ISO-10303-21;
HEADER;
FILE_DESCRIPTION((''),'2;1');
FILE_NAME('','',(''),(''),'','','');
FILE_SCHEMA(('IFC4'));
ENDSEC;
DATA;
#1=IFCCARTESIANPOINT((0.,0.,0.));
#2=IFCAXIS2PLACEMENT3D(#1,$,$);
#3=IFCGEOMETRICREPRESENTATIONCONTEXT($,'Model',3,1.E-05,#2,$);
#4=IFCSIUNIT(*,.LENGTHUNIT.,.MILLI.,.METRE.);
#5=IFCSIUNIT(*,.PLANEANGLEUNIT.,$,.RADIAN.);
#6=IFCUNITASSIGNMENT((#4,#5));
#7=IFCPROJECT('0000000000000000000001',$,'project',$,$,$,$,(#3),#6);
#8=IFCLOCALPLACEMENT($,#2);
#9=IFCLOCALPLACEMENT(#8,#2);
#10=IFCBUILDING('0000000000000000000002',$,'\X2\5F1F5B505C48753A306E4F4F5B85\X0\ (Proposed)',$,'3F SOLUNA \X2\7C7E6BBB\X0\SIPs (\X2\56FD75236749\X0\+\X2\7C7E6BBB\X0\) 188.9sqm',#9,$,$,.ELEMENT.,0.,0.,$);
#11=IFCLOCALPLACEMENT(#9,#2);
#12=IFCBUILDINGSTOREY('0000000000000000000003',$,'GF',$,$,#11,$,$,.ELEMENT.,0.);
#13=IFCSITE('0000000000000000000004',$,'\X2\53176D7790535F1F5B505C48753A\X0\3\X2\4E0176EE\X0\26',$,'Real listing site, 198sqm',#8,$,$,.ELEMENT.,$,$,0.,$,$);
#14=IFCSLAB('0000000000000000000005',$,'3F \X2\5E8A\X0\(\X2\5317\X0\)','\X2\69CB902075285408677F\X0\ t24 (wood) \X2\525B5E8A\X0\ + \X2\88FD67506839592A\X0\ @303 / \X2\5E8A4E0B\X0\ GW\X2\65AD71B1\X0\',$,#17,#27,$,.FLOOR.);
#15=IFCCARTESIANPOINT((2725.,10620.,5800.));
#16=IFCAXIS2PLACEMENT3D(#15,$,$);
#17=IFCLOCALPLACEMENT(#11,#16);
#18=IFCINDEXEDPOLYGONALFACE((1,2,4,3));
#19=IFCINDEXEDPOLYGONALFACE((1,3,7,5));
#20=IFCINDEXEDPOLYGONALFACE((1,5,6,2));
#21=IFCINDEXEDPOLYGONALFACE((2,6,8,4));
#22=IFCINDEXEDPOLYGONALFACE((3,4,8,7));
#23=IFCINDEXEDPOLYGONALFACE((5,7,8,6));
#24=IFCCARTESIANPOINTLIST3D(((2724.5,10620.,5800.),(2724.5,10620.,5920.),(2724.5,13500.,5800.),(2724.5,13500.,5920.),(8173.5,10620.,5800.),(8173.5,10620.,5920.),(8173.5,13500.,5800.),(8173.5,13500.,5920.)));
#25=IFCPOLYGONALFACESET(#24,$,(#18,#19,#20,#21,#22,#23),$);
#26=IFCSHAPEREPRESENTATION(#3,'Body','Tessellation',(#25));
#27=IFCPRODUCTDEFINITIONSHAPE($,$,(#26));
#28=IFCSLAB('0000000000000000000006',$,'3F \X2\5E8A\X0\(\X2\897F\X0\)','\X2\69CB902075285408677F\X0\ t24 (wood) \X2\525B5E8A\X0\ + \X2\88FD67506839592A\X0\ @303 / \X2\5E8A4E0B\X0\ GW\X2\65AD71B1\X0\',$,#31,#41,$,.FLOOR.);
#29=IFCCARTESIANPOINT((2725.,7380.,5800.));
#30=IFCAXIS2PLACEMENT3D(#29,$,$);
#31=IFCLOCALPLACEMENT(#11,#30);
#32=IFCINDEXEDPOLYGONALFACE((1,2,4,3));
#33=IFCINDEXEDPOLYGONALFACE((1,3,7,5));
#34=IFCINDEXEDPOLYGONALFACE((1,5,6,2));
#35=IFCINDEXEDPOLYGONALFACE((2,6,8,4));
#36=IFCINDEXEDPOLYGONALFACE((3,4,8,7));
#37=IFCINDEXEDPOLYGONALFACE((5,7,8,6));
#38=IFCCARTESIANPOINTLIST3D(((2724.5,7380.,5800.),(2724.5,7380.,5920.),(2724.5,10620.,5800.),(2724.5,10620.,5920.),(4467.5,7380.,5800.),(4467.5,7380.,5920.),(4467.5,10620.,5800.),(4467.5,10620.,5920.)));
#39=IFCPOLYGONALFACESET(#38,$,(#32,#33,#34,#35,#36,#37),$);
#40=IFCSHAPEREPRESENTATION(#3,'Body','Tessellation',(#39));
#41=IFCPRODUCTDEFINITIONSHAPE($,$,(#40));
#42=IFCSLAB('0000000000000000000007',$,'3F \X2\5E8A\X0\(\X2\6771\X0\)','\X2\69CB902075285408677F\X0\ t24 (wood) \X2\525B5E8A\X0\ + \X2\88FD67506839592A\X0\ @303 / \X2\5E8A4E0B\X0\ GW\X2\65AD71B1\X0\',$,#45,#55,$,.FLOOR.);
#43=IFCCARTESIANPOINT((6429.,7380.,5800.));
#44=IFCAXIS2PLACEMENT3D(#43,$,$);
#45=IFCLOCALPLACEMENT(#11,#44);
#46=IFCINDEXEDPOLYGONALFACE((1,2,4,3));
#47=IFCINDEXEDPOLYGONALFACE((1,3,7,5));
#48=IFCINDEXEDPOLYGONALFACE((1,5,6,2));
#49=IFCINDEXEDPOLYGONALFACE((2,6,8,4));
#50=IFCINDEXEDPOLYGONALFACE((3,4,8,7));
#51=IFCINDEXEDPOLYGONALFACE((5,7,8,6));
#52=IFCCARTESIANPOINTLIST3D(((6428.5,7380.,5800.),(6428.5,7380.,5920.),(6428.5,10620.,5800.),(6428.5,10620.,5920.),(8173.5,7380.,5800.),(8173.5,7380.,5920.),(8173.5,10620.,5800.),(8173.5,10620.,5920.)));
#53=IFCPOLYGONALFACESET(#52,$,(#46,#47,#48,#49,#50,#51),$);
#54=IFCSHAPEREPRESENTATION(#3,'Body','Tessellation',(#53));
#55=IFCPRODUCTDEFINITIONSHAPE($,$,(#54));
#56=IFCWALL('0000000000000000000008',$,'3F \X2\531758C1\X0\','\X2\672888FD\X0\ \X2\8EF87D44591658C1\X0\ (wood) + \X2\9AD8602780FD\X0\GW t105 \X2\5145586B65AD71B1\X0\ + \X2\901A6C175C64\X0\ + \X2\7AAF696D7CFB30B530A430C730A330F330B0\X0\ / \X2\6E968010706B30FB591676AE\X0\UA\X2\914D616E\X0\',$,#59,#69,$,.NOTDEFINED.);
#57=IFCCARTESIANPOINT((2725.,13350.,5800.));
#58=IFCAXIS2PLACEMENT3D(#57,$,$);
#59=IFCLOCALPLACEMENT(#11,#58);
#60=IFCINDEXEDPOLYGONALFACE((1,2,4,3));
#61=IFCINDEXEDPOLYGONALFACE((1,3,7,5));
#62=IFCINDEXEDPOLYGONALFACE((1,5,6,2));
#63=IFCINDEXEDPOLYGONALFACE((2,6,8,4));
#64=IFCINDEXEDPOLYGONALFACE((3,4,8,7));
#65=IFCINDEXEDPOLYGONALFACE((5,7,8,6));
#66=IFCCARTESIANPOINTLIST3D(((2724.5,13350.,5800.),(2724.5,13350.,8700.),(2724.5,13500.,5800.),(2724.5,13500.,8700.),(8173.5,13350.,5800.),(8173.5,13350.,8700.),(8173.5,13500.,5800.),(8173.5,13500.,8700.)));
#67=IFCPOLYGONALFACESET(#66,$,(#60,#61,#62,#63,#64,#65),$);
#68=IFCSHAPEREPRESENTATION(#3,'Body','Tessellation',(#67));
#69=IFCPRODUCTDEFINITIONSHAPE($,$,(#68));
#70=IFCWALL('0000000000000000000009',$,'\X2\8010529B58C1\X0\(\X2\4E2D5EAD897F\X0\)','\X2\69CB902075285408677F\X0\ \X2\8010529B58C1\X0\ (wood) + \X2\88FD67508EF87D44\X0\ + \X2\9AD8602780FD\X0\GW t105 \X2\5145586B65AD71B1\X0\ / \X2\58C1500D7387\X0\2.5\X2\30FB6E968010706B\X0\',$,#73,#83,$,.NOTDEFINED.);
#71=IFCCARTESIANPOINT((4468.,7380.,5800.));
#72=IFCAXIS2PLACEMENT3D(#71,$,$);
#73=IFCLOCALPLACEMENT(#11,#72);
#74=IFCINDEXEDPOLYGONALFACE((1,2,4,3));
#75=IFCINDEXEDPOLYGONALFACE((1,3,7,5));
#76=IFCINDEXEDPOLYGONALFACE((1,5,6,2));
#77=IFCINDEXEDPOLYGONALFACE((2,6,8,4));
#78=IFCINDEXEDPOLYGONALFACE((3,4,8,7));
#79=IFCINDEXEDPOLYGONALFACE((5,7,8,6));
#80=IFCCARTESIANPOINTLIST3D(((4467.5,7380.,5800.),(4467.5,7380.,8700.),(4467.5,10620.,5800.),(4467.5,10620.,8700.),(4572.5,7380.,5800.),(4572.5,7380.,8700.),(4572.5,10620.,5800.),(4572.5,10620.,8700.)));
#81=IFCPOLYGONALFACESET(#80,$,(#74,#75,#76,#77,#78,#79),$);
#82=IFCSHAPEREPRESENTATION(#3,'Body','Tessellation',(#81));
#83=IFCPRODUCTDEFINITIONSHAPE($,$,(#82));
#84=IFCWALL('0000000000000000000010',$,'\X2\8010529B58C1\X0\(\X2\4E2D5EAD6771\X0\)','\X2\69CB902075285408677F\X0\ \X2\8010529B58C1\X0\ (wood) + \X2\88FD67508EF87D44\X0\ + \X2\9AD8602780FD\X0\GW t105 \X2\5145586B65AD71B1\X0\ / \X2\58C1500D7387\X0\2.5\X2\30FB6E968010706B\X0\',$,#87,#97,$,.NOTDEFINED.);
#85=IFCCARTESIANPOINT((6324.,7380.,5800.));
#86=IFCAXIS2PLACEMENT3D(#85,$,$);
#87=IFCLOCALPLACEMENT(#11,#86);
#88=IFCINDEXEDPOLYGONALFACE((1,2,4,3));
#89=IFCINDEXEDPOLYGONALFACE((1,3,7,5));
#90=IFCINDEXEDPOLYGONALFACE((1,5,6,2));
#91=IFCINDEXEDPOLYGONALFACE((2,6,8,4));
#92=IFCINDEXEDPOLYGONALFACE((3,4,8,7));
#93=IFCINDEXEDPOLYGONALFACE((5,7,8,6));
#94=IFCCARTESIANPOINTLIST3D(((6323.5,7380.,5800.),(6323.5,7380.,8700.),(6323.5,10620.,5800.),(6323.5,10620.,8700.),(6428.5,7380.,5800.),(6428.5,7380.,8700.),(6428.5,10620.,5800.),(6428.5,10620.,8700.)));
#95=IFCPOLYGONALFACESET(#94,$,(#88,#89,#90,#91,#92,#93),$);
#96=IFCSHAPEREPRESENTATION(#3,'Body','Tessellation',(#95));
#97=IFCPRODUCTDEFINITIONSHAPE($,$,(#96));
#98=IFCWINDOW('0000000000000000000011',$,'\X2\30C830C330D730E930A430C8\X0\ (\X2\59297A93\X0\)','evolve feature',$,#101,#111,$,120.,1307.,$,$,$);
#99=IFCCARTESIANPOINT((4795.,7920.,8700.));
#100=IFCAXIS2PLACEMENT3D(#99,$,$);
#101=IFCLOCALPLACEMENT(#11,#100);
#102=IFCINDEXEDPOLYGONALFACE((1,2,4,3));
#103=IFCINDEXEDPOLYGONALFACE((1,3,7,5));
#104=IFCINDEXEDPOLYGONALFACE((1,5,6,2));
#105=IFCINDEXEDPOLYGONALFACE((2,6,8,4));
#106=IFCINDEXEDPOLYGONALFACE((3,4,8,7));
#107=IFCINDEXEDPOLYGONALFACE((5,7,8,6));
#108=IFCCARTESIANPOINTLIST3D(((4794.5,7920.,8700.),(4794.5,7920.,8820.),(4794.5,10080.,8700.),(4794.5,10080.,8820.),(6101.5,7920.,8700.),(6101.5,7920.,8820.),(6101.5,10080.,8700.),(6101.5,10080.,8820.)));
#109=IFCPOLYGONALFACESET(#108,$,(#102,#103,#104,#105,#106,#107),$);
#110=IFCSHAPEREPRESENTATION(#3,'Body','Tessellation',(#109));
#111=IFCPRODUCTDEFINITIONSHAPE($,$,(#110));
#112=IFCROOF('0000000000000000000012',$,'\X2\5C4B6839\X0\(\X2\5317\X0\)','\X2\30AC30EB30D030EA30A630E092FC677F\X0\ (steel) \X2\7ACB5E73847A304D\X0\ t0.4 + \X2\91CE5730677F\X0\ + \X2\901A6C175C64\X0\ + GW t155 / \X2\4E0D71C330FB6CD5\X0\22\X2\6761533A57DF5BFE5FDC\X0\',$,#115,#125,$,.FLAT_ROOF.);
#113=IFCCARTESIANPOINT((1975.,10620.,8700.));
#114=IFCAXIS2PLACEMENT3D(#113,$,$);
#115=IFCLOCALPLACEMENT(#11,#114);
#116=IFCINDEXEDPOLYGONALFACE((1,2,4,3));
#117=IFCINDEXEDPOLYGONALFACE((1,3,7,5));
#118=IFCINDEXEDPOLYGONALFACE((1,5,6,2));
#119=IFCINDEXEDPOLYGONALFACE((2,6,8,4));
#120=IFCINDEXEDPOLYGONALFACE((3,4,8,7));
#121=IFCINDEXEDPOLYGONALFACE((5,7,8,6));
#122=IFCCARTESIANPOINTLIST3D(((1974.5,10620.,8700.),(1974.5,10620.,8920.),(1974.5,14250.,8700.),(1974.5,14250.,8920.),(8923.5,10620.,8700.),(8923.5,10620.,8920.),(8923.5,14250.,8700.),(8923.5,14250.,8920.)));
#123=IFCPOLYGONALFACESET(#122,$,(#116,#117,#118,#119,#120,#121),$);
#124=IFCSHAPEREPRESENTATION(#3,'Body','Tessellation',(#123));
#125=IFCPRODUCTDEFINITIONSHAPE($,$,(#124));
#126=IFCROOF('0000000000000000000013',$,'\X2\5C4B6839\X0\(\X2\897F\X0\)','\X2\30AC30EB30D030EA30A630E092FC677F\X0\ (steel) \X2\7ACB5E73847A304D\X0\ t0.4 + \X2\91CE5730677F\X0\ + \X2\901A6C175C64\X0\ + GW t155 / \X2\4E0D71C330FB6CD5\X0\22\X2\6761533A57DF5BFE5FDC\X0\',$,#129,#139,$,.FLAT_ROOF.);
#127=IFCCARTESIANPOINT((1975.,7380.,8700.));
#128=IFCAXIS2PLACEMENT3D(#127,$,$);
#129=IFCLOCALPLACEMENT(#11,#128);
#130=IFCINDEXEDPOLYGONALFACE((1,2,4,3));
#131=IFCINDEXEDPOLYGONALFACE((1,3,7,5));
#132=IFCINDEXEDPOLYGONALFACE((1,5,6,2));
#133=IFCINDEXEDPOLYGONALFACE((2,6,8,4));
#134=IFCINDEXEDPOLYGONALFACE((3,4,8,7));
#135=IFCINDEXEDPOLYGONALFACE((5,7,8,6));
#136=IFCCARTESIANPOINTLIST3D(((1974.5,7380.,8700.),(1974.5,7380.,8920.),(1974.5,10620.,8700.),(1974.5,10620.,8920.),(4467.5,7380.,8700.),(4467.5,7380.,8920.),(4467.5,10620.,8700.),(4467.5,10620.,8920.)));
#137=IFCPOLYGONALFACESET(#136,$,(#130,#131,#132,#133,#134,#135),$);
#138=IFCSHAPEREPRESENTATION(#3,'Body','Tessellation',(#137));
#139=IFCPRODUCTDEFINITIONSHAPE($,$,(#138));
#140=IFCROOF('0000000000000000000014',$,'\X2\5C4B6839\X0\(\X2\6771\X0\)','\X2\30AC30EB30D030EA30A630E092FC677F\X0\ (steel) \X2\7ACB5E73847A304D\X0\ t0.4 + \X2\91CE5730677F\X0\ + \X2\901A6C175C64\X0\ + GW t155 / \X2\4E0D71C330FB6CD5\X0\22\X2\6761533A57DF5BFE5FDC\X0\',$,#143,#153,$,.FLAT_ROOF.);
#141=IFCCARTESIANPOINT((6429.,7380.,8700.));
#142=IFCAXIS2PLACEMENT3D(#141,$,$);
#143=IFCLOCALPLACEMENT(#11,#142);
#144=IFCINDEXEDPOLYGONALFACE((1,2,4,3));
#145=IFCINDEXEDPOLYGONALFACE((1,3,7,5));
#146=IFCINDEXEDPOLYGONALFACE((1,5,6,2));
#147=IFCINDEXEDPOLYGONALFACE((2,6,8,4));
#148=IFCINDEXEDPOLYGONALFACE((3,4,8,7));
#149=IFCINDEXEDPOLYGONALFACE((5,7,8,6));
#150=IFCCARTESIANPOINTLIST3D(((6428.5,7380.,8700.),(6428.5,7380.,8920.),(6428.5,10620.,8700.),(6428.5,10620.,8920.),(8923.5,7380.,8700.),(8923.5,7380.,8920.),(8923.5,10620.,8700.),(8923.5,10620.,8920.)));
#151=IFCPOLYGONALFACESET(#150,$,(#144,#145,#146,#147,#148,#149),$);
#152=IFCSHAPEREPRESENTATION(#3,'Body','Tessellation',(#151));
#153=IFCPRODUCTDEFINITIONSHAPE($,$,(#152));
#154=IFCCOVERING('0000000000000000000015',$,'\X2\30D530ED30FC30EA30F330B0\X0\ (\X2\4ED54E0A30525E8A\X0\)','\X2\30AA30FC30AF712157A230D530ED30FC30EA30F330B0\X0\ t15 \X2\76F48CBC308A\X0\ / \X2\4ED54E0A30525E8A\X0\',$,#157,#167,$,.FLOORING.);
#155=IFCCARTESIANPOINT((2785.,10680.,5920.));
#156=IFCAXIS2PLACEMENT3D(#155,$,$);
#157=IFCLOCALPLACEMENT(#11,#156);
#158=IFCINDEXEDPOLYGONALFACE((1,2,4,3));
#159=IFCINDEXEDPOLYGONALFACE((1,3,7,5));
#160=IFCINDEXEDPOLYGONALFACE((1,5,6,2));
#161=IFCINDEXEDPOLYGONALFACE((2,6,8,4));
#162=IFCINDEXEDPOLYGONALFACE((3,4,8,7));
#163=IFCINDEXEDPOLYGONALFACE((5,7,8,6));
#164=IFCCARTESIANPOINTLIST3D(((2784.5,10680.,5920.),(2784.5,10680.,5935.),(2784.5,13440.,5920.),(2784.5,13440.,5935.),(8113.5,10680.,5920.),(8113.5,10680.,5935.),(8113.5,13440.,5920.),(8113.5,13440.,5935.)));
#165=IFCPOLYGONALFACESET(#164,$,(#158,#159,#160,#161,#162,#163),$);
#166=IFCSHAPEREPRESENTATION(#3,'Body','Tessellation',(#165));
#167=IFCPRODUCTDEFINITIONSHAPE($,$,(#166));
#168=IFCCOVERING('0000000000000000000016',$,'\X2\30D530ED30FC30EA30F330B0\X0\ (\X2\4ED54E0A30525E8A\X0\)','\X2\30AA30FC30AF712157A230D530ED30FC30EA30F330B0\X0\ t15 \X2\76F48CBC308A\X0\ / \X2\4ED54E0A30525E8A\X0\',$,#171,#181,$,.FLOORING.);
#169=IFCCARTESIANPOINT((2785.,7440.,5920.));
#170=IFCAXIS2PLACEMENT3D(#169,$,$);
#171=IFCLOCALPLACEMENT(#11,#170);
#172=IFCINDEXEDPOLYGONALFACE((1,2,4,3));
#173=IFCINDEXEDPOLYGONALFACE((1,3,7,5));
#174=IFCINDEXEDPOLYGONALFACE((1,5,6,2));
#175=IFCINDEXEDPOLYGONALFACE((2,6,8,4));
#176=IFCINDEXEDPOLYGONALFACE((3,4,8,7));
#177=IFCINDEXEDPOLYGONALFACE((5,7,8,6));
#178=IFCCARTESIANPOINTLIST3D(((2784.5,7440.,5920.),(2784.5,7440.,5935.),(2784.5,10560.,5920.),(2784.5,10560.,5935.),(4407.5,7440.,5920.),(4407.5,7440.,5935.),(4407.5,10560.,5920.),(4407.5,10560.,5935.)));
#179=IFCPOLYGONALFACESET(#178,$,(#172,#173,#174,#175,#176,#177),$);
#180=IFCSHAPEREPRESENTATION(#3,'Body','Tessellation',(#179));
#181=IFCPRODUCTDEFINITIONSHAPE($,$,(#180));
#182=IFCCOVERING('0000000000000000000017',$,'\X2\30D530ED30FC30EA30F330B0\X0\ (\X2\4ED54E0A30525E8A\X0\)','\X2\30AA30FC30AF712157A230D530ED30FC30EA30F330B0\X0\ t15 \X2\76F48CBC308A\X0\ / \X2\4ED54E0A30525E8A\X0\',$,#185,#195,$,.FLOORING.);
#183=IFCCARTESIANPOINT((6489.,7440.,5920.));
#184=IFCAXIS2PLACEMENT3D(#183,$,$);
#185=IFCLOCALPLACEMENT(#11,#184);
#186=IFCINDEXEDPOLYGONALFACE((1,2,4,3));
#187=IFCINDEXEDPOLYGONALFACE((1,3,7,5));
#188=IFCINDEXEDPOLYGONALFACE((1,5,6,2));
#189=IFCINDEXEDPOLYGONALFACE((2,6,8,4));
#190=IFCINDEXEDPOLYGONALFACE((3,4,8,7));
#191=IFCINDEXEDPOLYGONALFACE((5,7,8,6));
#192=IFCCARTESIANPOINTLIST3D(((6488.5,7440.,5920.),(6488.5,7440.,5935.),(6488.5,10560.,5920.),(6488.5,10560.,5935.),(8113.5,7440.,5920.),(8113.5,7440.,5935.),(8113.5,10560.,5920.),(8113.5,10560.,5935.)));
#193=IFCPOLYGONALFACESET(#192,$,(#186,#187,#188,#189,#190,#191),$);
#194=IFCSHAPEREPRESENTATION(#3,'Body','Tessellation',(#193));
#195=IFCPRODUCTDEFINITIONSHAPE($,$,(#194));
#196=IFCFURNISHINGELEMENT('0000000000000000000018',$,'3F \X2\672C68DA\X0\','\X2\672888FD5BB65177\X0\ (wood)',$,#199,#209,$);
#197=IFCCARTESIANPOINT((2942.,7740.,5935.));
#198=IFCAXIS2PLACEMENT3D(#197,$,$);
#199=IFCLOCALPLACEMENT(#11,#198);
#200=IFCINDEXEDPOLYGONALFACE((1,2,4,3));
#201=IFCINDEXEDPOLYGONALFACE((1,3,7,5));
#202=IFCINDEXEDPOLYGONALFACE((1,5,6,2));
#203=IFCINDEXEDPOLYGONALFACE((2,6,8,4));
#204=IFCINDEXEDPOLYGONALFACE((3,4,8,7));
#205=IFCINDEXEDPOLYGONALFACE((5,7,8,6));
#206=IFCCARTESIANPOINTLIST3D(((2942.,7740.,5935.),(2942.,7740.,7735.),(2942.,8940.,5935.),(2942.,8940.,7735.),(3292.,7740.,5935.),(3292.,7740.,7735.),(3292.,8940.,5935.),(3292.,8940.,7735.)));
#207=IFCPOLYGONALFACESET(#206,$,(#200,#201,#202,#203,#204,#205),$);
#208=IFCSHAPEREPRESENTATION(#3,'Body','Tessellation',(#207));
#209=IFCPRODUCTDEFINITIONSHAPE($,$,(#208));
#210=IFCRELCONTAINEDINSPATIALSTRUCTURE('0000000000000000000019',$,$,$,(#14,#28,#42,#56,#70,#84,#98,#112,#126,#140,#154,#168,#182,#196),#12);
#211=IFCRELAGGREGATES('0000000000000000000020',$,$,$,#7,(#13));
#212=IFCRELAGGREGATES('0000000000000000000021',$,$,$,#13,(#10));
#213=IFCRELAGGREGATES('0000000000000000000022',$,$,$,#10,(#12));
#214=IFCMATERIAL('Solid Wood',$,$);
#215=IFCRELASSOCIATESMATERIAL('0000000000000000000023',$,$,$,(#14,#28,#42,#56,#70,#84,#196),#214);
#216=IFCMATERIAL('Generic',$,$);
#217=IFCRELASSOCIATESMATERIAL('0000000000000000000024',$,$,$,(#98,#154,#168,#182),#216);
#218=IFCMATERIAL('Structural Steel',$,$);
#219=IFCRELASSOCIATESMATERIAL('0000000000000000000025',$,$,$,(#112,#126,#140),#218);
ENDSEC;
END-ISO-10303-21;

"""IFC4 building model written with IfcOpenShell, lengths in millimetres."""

from ifc_helpers import new_model, si_unit, frame, frame_2d, origin, place, context, project, spatial, rectangle, extrude, material, element, save


model = new_model("IFC4")

# Units and contexts
model_context = context("Model", 3, precision=1e-05, world=origin())
ifc_project = project(units=[si_unit("LENGTHUNIT", "METRE", prefix="MILLI"), si_unit("PLANEANGLEUNIT", "RADIAN")], contexts=[model_context])

# Site, building, storey
site_placement = place(None, origin())
site = spatial("IfcSite", under=ifc_project, at=site_placement, Name="北海道弟子屈町3丁目26", ObjectType="Real listing site, 198sqm", CompositionType="ELEMENT", RefElevation=0.0)
building_placement = place(site_placement, origin())
building = spatial("IfcBuilding", under=site, at=building_placement, Name="弟子屈町の住宅 (Proposed)", ObjectType="3F SOLUNA 籾殻SIPs (国産杉+籾殻) 188.9sqm", CompositionType="ELEMENT", ElevationOfRefHeight=0.0, ElevationOfTerrain=0.0)
storey_placement = place(building_placement, origin())
storey = spatial("IfcBuildingStorey", under=building, at=storey_placement, Name="GF", CompositionType="ELEMENT", Elevation=0.0)

# Slabs
ifc_material_1 = material(Name="Solid Wood")
slab_1_placement = place(storey_placement, frame((2725.0, 10620.0, 5800.0)))
element("IfcSlab", 1, at=slab_1_placement, inside=storey, material=ifc_material_1, Name="3F 床(北)", Description="構造用合板 t24 (wood) 剛床 + 製材根太 @303 / 床下 GW断熱", PredefinedType="FLOOR", context=model_context, shape_type="SweptSolid", body=[
    extrude(rectangle(XDim=5449.0, YDim=2880.0, at=frame_2d((2724.0, 1440.0))), frame((2725.0, 10620.0, 5800.0)), (0.0, 0.0, 1.0), 120.0),
])
slab_2_placement = place(storey_placement, frame((2725.0, 7380.0, 5800.0)))
element("IfcSlab", 2, at=slab_2_placement, inside=storey, material=ifc_material_1, Name="3F 床(西)", Description="構造用合板 t24 (wood) 剛床 + 製材根太 @303 / 床下 GW断熱", PredefinedType="FLOOR", context=model_context, shape_type="SweptSolid", body=[
    extrude(rectangle(XDim=1743.0, YDim=3240.0, at=frame_2d((871.0, 1620.0))), frame((2725.0, 7380.0, 5800.0)), (0.0, 0.0, 1.0), 120.0),
])
slab_3_placement = place(storey_placement, frame((6429.0, 7380.0, 5800.0)))
element("IfcSlab", 3, at=slab_3_placement, inside=storey, material=ifc_material_1, Name="3F 床(東)", Description="構造用合板 t24 (wood) 剛床 + 製材根太 @303 / 床下 GW断熱", PredefinedType="FLOOR", context=model_context, shape_type="SweptSolid", body=[
    extrude(rectangle(XDim=1745.0, YDim=3240.0, at=frame_2d((872.0, 1620.0))), frame((6429.0, 7380.0, 5800.0)), (0.0, 0.0, 1.0), 120.0),
])

# Wall
wall_1_placement = place(storey_placement, frame((2725.0, 13350.0, 5800.0)))
element("IfcWall", 4, at=wall_1_placement, inside=storey, material=ifc_material_1, Name="3F 北壁", Description="木製 軸組外壁 (wood) + 高性能GW t105 充填断熱 + 通気層 + 窯業系サイディング / 準耐火・外皮UA配慮", PredefinedType="NOTDEFINED", context=model_context, shape_type="SweptSolid", body=[
    extrude(rectangle(XDim=5449.0, YDim=150.0, at=frame_2d((2724.0, 75.0))), frame((2725.0, 13350.0, 5800.0)), (0.0, 0.0, 1.0), 2900.0),
])

# Walls
wall_2_placement = place(storey_placement, frame((4468.0, 7380.0, 5800.0)))
element("IfcWall", 5, at=wall_2_placement, inside=storey, material=ifc_material_1, Name="耐力壁(中庭西)", Description="構造用合板 耐力壁 (wood) + 製材軸組 + 高性能GW t105 充填断熱 / 壁倍率2.5・準耐火", PredefinedType="NOTDEFINED", context=model_context, shape_type="SweptSolid", body=[
    extrude(rectangle(XDim=105.0, YDim=3240.0, at=frame_2d((52.0, 1620.0))), frame((4468.0, 7380.0, 5800.0)), (0.0, 0.0, 1.0), 2900.0),
])
wall_3_placement = place(storey_placement, frame((6324.0, 7380.0, 5800.0)))
element("IfcWall", 6, at=wall_3_placement, inside=storey, material=ifc_material_1, Name="耐力壁(中庭東)", Description="構造用合板 耐力壁 (wood) + 製材軸組 + 高性能GW t105 充填断熱 / 壁倍率2.5・準耐火", PredefinedType="NOTDEFINED", context=model_context, shape_type="SweptSolid", body=[
    extrude(rectangle(XDim=105.0, YDim=3240.0, at=frame_2d((52.0, 1620.0))), frame((6324.0, 7380.0, 5800.0)), (0.0, 0.0, 1.0), 2900.0),
])

# Window
ifc_material_2 = material(Name="Generic")
window_1_placement = place(storey_placement, frame((4795.0, 7920.0, 8700.0)))
element("IfcWindow", 7, at=window_1_placement, inside=storey, material=ifc_material_2, Name="トップライト (天窓)", Description="evolve feature", OverallHeight=120.0, OverallWidth=1307.0, context=model_context, shape_type="SweptSolid", body=[
    extrude(rectangle(XDim=1307.0, YDim=2160.0, at=frame_2d((653.0, 1080.0))), frame((4795.0, 7920.0, 8700.0)), (0.0, 0.0, 1.0), 120.0),
])

# Roofs
ifc_material_3 = material(Name="Structural Steel")
for number, where, name in (
    (8, (1975.0, 10620.0, 8700.0), "屋根(北)"),
):
    element("IfcRoof", number, at=place(storey_placement, frame(where)), inside=storey, material=ifc_material_3, Name=name, Description="ガルバリウム鋼板 (steel) 立平葺き t0.4 + 野地板 + 通気層 + GW t155 / 不燃・法22条区域対応", PredefinedType="FLAT_ROOF", context=model_context, shape_type="SweptSolid", body=[
        extrude(rectangle(XDim=6949.0, YDim=3630.0, at=frame_2d((3474.0, 1815.0))), frame((1975.0, 10620.0, 8700.0)), (0.0, 0.0, 1.0), 220.0),
    ])
roof_1_placement = place(storey_placement, frame((1975.0, 7380.0, 8700.0)))
element("IfcRoof", 9, at=roof_1_placement, inside=storey, material=ifc_material_3, Name="屋根(西)", Description="ガルバリウム鋼板 (steel) 立平葺き t0.4 + 野地板 + 通気層 + GW t155 / 不燃・法22条区域対応", PredefinedType="FLAT_ROOF", context=model_context, shape_type="SweptSolid", body=[
    extrude(rectangle(XDim=2493.0, YDim=3240.0, at=frame_2d((1246.0, 1620.0))), frame((1975.0, 7380.0, 8700.0)), (0.0, 0.0, 1.0), 220.0),
])
roof_2_placement = place(storey_placement, frame((6429.0, 7380.0, 8700.0)))
element("IfcRoof", 10, at=roof_2_placement, inside=storey, material=ifc_material_3, Name="屋根(東)", Description="ガルバリウム鋼板 (steel) 立平葺き t0.4 + 野地板 + 通気層 + GW t155 / 不燃・法22条区域対応", PredefinedType="FLAT_ROOF", context=model_context, shape_type="SweptSolid", body=[
    extrude(rectangle(XDim=2495.0, YDim=3240.0, at=frame_2d((1247.0, 1620.0))), frame((6429.0, 7380.0, 8700.0)), (0.0, 0.0, 1.0), 220.0),
])

# Coverings
covering_1_placement = place(storey_placement, frame((2785.0, 10680.0, 5920.0)))
element("IfcCovering", 11, at=covering_1_placement, inside=storey, material=ifc_material_2, Name="フローリング (仕上げ床)", Description="オーク無垢フローリング t15 直貼り / 仕上げ床", PredefinedType="FLOORING", context=model_context, shape_type="SweptSolid", body=[
    extrude(rectangle(XDim=5329.0, YDim=2760.0, at=frame_2d((2664.0, 1380.0))), frame((2785.0, 10680.0, 5920.0)), (0.0, 0.0, 1.0), 15.0),
])
covering_2_placement = place(storey_placement, frame((2785.0, 7440.0, 5920.0)))
element("IfcCovering", 12, at=covering_2_placement, inside=storey, material=ifc_material_2, Name="フローリング (仕上げ床)", Description="オーク無垢フローリング t15 直貼り / 仕上げ床", PredefinedType="FLOORING", context=model_context, shape_type="SweptSolid", body=[
    extrude(rectangle(XDim=1623.0, YDim=3120.0, at=frame_2d((811.0, 1560.0))), frame((2785.0, 7440.0, 5920.0)), (0.0, 0.0, 1.0), 15.0),
])
covering_3_placement = place(storey_placement, frame((6489.0, 7440.0, 5920.0)))
element("IfcCovering", 13, at=covering_3_placement, inside=storey, material=ifc_material_2, Name="フローリング (仕上げ床)", Description="オーク無垢フローリング t15 直貼り / 仕上げ床", PredefinedType="FLOORING", context=model_context, shape_type="SweptSolid", body=[
    extrude(rectangle(XDim=1625.0, YDim=3120.0, at=frame_2d((812.0, 1560.0))), frame((6489.0, 7440.0, 5920.0)), (0.0, 0.0, 1.0), 15.0),
])

# Furnishing element
furnishing_placement = place(storey_placement, frame((2942.0, 7740.0, 5935.0)))
element("IfcFurnishingElement", 14, at=furnishing_placement, inside=storey, material=ifc_material_1, Name="3F 本棚", Description="木製家具 (wood)", context=model_context, shape_type="SweptSolid", body=[
    extrude(rectangle(XDim=350.0, YDim=1200.0, at=frame_2d((175.0, 600.0))), frame((2942.0, 7740.0, 5935.0)), (0.0, 0.0, 1.0), 1800.0),
])

save(model, "model.ifc")
